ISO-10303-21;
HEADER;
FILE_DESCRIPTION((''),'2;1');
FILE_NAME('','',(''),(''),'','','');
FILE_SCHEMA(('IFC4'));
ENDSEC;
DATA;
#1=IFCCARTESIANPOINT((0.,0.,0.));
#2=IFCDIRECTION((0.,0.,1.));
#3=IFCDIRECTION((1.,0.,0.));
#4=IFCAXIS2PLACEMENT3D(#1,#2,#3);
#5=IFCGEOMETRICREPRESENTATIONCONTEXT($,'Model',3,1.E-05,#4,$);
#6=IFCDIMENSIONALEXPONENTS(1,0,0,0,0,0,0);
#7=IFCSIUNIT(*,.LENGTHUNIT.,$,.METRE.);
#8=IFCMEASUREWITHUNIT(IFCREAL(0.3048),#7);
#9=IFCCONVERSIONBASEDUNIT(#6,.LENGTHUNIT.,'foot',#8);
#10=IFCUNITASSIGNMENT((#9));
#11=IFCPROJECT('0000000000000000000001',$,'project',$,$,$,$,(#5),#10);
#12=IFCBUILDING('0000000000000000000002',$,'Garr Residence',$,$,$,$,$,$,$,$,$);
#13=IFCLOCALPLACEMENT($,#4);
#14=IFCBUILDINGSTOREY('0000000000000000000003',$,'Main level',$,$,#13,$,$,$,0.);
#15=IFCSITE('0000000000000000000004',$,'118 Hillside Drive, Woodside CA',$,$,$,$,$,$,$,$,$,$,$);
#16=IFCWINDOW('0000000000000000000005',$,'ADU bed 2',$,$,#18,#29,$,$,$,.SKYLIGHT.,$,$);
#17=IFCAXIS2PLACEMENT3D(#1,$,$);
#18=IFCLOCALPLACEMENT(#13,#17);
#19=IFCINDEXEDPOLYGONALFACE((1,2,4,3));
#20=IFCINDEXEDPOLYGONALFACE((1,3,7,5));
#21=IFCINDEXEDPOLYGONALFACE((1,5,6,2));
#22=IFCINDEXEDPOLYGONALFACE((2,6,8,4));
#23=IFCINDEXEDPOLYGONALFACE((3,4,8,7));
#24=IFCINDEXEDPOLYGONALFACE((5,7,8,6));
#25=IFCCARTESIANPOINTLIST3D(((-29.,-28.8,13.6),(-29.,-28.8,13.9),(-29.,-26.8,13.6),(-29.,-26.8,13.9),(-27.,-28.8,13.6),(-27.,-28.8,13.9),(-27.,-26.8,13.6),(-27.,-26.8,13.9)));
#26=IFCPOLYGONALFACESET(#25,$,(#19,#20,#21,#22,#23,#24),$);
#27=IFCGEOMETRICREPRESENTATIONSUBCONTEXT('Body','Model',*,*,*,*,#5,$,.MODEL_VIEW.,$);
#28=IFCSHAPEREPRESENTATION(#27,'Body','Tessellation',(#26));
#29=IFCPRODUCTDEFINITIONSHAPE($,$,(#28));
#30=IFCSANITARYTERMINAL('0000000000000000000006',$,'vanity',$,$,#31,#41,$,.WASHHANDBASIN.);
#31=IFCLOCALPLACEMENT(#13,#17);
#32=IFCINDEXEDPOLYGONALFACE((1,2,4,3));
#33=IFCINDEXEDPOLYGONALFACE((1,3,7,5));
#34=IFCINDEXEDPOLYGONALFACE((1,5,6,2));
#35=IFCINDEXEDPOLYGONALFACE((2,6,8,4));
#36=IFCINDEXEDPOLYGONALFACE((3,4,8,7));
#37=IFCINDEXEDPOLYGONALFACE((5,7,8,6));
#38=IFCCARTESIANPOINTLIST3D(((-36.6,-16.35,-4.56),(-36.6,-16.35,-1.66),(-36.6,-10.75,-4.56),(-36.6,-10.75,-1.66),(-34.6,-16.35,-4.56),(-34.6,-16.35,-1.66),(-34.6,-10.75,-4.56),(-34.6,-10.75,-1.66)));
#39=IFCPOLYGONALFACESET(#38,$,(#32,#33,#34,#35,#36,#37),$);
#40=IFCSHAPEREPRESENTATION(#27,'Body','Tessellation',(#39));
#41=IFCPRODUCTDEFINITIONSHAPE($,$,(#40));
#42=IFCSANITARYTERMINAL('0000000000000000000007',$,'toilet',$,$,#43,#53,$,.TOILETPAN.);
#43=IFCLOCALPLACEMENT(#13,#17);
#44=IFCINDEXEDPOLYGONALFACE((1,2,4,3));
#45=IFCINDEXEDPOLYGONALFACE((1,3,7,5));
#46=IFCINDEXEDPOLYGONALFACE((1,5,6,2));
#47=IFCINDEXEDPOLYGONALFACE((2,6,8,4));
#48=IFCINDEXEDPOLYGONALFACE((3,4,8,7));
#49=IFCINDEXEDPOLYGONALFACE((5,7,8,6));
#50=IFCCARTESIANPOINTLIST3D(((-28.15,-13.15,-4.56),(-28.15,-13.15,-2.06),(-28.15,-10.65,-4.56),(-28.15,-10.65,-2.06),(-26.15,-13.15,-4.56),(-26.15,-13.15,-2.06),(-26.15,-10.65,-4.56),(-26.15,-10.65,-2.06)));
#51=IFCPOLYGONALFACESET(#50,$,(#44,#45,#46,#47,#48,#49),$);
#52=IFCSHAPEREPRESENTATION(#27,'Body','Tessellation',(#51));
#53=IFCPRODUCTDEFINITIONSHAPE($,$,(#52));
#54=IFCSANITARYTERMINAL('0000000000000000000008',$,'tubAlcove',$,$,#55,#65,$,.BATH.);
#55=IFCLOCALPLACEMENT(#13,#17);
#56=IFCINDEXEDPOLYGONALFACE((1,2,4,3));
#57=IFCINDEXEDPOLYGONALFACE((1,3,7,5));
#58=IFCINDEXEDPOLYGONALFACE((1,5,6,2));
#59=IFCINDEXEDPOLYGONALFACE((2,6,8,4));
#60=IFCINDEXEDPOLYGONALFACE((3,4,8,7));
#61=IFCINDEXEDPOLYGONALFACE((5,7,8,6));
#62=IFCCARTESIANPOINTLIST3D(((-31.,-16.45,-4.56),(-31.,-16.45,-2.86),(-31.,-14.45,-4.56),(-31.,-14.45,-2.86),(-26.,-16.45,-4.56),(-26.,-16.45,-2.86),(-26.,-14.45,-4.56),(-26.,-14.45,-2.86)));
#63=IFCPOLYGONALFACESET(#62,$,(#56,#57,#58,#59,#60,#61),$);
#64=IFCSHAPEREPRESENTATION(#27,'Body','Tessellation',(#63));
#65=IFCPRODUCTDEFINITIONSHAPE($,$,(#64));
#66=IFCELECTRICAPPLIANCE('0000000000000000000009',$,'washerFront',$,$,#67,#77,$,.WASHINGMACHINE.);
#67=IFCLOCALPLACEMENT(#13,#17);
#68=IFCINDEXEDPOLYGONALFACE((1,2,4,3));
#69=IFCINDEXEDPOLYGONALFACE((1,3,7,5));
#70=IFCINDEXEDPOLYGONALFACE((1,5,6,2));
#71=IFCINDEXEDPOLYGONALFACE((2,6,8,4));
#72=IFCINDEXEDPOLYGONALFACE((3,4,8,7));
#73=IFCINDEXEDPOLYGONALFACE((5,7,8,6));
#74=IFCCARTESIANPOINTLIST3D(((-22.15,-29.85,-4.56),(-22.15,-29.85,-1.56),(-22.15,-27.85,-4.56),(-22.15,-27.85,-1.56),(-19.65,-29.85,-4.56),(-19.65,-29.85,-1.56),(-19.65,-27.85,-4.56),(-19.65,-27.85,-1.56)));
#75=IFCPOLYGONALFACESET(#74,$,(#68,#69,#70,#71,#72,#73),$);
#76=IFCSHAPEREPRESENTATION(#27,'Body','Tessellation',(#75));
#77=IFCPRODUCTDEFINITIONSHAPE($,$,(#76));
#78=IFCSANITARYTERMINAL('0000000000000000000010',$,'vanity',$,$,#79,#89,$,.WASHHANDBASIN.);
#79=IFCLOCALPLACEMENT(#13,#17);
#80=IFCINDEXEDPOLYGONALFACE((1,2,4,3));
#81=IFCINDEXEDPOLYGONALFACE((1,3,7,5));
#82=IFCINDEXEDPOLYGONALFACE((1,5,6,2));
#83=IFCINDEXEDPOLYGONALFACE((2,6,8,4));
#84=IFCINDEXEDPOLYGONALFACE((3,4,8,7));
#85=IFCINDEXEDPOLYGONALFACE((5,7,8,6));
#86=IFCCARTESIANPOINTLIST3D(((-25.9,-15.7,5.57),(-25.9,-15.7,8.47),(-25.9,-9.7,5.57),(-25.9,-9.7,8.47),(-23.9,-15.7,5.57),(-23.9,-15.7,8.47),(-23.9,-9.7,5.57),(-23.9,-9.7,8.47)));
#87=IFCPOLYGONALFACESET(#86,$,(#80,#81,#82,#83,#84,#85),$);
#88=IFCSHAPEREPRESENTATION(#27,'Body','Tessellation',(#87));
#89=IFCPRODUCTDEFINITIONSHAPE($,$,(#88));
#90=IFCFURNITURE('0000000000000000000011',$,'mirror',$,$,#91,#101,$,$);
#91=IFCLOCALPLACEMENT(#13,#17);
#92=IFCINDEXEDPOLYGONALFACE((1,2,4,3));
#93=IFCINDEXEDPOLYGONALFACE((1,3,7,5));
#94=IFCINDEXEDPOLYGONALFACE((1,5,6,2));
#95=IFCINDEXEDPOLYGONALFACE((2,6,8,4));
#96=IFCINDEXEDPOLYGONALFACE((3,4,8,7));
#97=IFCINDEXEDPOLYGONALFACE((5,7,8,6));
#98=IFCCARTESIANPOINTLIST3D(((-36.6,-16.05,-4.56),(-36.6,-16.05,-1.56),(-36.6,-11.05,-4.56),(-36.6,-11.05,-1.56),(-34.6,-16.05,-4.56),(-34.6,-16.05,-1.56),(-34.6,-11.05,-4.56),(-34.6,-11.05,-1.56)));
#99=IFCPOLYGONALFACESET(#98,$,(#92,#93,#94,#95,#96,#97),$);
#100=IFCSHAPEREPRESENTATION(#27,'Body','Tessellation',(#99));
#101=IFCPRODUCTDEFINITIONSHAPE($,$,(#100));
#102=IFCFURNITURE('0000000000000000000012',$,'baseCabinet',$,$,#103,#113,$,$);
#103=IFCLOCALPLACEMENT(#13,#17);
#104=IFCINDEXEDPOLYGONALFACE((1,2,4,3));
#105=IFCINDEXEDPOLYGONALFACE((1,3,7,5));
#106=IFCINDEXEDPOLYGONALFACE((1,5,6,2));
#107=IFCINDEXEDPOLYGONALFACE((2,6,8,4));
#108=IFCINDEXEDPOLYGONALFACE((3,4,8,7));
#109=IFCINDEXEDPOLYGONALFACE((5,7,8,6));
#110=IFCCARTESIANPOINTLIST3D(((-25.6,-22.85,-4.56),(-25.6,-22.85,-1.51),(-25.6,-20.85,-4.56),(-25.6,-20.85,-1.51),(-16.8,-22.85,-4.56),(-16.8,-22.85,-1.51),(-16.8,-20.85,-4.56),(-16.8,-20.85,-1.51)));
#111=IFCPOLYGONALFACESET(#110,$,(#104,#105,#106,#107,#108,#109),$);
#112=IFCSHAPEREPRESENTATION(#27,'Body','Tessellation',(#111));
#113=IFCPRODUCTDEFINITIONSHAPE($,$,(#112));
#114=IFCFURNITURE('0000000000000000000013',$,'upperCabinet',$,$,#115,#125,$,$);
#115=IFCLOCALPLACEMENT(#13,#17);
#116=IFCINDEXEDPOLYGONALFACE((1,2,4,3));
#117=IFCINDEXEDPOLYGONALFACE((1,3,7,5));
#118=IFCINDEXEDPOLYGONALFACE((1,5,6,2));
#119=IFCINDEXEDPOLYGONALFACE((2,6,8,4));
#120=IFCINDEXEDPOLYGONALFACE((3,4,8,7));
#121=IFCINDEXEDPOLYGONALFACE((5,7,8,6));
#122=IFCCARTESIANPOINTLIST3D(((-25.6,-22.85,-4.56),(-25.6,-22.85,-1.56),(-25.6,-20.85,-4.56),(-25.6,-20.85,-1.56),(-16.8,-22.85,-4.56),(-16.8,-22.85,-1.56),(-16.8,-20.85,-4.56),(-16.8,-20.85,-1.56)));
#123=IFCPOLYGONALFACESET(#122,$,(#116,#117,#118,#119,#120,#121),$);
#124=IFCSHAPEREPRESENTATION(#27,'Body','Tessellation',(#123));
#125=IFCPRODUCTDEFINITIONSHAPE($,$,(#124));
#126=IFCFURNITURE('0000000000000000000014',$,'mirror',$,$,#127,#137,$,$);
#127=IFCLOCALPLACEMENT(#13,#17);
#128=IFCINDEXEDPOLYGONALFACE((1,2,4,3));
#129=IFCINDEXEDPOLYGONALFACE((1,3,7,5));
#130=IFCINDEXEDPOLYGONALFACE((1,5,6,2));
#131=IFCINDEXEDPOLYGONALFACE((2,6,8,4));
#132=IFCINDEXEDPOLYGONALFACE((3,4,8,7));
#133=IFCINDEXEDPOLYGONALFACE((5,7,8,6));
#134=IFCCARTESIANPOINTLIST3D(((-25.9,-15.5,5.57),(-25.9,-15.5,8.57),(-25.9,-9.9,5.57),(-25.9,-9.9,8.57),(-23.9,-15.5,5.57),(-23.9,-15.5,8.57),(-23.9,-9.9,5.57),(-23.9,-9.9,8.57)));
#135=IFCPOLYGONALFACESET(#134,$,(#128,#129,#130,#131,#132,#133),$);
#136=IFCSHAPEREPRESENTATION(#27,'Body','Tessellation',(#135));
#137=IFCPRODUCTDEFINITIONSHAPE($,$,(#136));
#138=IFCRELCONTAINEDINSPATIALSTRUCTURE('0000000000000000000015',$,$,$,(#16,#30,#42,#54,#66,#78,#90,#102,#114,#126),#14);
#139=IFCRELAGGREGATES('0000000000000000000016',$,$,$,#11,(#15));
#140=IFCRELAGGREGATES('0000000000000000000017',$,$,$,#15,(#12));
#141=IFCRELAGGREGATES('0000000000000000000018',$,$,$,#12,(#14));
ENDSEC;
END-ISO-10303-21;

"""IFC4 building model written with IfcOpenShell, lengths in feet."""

from ifc_helpers import new_model, entity, si_unit, converted_unit, frame, origin, origin_with_axes, place, context, subcontext, project, spatial, polyline, outline, extrude, element, save


model = new_model("IFC4")

# Units and contexts
model_context = context("Model", 3, precision=1e-05, world=origin_with_axes())
body_context = subcontext(model_context, "Body", "Model", "MODEL_VIEW")
ifc_project = project(units=[converted_unit("LENGTHUNIT", "foot", entity("IfcReal", 0.3048), si_unit("LENGTHUNIT", "METRE"), dimensions=[1, 0, 0, 0, 0, 0, 0])], contexts=[model_context])

# Site, building, storey
site = spatial("IfcSite", under=ifc_project, Name="118 Hillside Drive, Woodside CA")
building = spatial("IfcBuilding", under=site, Name="Garr Residence")
storey_placement = place(None, origin_with_axes())
storey = spatial("IfcBuildingStorey", under=building, at=storey_placement, Name="Main level", Elevation=0.0)

# Window
for number, where, z_axis, x_axis, name in (
    (1, (-28.0, -27.8, 13.6), (0.0, 0.0, 1.0), (1.0, 0.0, 0.0), "ADU bed 2"),
):
    element("IfcWindow", number, at=place(storey_placement, frame(where, z_axis=z_axis, x_axis=x_axis)), inside=storey, Name=name, PredefinedType="SKYLIGHT", context=body_context, shape_type="SweptSolid", body=[
        extrude(outline(polyline([(-1.0, -1.0), (1.0, -1.0), (1.0, 1.0), (-1.0, 1.0), (-1.0, -1.0)])), origin(), (0.0, 0.0, 1.0), 0.3),
    ])

# Sanitary terminals
sanitary_terminal_1_placement = place(storey_placement, frame((-36.6, -13.55, -4.56), z_axis=(0.0, 0.0, 1.0), x_axis=(0.0, -1.0, 0.0)))
element("IfcSanitaryTerminal", 2, at=sanitary_terminal_1_placement, inside=storey, Name="vanity", PredefinedType="WASHHANDBASIN", context=body_context, shape_type="SweptSolid", body=[
    extrude(outline(polyline([(-2.8, 0.0), (2.8, 0.0), (2.8, 2.0), (-2.8, 2.0), (-2.8, 0.0)])), origin(), (0.0, 0.0, 1.0), 2.9),
])
sanitary_terminal_2_placement = place(storey_placement, frame((-26.15, -11.9, -4.56), z_axis=(0.0, 0.0, 1.0), x_axis=(0.0, 1.0, 0.0)))
element("IfcSanitaryTerminal", 3, at=sanitary_terminal_2_placement, inside=storey, Name="toilet", PredefinedType="TOILETPAN", context=body_context, shape_type="SweptSolid", body=[
    extrude(outline(polyline([(-1.25, 0.0), (1.25, 0.0), (1.25, 2.0), (-1.25, 2.0), (-1.25, 0.0)])), origin(), (0.0, 0.0, 1.0), 2.5),
])
sanitary_terminal_3_placement = place(storey_placement, frame((-28.5, -16.45, -4.56), z_axis=(0.0, 0.0, 1.0), x_axis=(1.0, 0.0, 0.0)))
element("IfcSanitaryTerminal", 4, at=sanitary_terminal_3_placement, inside=storey, Name="tubAlcove", PredefinedType="BATH", context=body_context, shape_type="SweptSolid", body=[
    extrude(outline(polyline([(-2.5, 0.0), (2.5, 0.0), (2.5, 2.0), (-2.5, 2.0), (-2.5, 0.0)])), origin(), (0.0, 0.0, 1.0), 1.7),
])

# Electric appliance
electric_appliance_placement = place(storey_placement, frame((-20.9, -29.85, -4.56), z_axis=(0.0, 0.0, 1.0), x_axis=(1.0, 0.0, 0.0)))
element("IfcElectricAppliance", 5, at=electric_appliance_placement, inside=storey, Name="washerFront", PredefinedType="WASHINGMACHINE", context=body_context, shape_type="SweptSolid", body=[
    extrude(outline(polyline([(-1.25, 0.0), (1.25, 0.0), (1.25, 2.0), (-1.25, 2.0), (-1.25, 0.0)])), origin(), (0.0, 0.0, 1.0), 3.0),
])

# Sanitary terminal
sanitary_terminal_4_placement = place(storey_placement, frame((-25.9, -12.7, 5.57), z_axis=(0.0, 0.0, 1.0), x_axis=(0.0, -1.0, 0.0)))
element("IfcSanitaryTerminal", 6, at=sanitary_terminal_4_placement, inside=storey, Name="vanity", PredefinedType="WASHHANDBASIN", context=body_context, shape_type="SweptSolid", body=[
    extrude(outline(polyline([(-3.0, 0.0), (3.0, 0.0), (3.0, 2.0), (-3.0, 2.0), (-3.0, 0.0)])), origin(), (0.0, 0.0, 1.0), 2.9),
])

# Furniture
furniture_1_placement = place(storey_placement, frame((-36.6, -13.55, -4.56), z_axis=(0.0, 0.0, 1.0), x_axis=(0.0, -1.0, 0.0)))
element("IfcFurniture", 7, at=furniture_1_placement, inside=storey, Name="mirror", context=body_context, shape_type="SweptSolid", body=[
    extrude(outline(polyline([(-2.5, 0.0), (2.5, 0.0), (2.5, 2.0), (-2.5, 2.0), (-2.5, 0.0)])), origin(), (0.0, 0.0, 1.0), 3.0),
])
furniture_2_placement = place(storey_placement, frame((-21.2, -22.85, -4.56), z_axis=(0.0, 0.0, 1.0), x_axis=(1.0, 0.0, 0.0)))
element("IfcFurniture", 8, at=furniture_2_placement, inside=storey, Name="baseCabinet", context=body_context, shape_type="SweptSolid", body=[
    extrude(outline(polyline([(-4.4, 0.0), (4.4, 0.0), (4.4, 2.0), (-4.4, 2.0), (-4.4, 0.0)])), origin(), (0.0, 0.0, 1.0), 3.05),
])
furniture_3_placement = place(storey_placement, frame((-21.2, -22.85, -4.56), z_axis=(0.0, 0.0, 1.0), x_axis=(1.0, 0.0, 0.0)))
element("IfcFurniture", 9, at=furniture_3_placement, inside=storey, Name="upperCabinet", context=body_context, shape_type="SweptSolid", body=[
    extrude(outline(polyline([(-4.4, 0.0), (4.4, 0.0), (4.4, 2.0), (-4.4, 2.0), (-4.4, 0.0)])), origin(), (0.0, 0.0, 1.0), 3.0),
])
furniture_4_placement = place(storey_placement, frame((-25.9, -12.7, 5.57), z_axis=(0.0, 0.0, 1.0), x_axis=(0.0, -1.0, 0.0)))
element("IfcFurniture", 10, at=furniture_4_placement, inside=storey, Name="mirror", context=body_context, shape_type="SweptSolid", body=[
    extrude(outline(polyline([(-2.8, 0.0), (2.8, 0.0), (2.8, 2.0), (-2.8, 2.0), (-2.8, 0.0)])), origin(), (0.0, 0.0, 1.0), 3.0),
])

save(model, "model.ifc")
